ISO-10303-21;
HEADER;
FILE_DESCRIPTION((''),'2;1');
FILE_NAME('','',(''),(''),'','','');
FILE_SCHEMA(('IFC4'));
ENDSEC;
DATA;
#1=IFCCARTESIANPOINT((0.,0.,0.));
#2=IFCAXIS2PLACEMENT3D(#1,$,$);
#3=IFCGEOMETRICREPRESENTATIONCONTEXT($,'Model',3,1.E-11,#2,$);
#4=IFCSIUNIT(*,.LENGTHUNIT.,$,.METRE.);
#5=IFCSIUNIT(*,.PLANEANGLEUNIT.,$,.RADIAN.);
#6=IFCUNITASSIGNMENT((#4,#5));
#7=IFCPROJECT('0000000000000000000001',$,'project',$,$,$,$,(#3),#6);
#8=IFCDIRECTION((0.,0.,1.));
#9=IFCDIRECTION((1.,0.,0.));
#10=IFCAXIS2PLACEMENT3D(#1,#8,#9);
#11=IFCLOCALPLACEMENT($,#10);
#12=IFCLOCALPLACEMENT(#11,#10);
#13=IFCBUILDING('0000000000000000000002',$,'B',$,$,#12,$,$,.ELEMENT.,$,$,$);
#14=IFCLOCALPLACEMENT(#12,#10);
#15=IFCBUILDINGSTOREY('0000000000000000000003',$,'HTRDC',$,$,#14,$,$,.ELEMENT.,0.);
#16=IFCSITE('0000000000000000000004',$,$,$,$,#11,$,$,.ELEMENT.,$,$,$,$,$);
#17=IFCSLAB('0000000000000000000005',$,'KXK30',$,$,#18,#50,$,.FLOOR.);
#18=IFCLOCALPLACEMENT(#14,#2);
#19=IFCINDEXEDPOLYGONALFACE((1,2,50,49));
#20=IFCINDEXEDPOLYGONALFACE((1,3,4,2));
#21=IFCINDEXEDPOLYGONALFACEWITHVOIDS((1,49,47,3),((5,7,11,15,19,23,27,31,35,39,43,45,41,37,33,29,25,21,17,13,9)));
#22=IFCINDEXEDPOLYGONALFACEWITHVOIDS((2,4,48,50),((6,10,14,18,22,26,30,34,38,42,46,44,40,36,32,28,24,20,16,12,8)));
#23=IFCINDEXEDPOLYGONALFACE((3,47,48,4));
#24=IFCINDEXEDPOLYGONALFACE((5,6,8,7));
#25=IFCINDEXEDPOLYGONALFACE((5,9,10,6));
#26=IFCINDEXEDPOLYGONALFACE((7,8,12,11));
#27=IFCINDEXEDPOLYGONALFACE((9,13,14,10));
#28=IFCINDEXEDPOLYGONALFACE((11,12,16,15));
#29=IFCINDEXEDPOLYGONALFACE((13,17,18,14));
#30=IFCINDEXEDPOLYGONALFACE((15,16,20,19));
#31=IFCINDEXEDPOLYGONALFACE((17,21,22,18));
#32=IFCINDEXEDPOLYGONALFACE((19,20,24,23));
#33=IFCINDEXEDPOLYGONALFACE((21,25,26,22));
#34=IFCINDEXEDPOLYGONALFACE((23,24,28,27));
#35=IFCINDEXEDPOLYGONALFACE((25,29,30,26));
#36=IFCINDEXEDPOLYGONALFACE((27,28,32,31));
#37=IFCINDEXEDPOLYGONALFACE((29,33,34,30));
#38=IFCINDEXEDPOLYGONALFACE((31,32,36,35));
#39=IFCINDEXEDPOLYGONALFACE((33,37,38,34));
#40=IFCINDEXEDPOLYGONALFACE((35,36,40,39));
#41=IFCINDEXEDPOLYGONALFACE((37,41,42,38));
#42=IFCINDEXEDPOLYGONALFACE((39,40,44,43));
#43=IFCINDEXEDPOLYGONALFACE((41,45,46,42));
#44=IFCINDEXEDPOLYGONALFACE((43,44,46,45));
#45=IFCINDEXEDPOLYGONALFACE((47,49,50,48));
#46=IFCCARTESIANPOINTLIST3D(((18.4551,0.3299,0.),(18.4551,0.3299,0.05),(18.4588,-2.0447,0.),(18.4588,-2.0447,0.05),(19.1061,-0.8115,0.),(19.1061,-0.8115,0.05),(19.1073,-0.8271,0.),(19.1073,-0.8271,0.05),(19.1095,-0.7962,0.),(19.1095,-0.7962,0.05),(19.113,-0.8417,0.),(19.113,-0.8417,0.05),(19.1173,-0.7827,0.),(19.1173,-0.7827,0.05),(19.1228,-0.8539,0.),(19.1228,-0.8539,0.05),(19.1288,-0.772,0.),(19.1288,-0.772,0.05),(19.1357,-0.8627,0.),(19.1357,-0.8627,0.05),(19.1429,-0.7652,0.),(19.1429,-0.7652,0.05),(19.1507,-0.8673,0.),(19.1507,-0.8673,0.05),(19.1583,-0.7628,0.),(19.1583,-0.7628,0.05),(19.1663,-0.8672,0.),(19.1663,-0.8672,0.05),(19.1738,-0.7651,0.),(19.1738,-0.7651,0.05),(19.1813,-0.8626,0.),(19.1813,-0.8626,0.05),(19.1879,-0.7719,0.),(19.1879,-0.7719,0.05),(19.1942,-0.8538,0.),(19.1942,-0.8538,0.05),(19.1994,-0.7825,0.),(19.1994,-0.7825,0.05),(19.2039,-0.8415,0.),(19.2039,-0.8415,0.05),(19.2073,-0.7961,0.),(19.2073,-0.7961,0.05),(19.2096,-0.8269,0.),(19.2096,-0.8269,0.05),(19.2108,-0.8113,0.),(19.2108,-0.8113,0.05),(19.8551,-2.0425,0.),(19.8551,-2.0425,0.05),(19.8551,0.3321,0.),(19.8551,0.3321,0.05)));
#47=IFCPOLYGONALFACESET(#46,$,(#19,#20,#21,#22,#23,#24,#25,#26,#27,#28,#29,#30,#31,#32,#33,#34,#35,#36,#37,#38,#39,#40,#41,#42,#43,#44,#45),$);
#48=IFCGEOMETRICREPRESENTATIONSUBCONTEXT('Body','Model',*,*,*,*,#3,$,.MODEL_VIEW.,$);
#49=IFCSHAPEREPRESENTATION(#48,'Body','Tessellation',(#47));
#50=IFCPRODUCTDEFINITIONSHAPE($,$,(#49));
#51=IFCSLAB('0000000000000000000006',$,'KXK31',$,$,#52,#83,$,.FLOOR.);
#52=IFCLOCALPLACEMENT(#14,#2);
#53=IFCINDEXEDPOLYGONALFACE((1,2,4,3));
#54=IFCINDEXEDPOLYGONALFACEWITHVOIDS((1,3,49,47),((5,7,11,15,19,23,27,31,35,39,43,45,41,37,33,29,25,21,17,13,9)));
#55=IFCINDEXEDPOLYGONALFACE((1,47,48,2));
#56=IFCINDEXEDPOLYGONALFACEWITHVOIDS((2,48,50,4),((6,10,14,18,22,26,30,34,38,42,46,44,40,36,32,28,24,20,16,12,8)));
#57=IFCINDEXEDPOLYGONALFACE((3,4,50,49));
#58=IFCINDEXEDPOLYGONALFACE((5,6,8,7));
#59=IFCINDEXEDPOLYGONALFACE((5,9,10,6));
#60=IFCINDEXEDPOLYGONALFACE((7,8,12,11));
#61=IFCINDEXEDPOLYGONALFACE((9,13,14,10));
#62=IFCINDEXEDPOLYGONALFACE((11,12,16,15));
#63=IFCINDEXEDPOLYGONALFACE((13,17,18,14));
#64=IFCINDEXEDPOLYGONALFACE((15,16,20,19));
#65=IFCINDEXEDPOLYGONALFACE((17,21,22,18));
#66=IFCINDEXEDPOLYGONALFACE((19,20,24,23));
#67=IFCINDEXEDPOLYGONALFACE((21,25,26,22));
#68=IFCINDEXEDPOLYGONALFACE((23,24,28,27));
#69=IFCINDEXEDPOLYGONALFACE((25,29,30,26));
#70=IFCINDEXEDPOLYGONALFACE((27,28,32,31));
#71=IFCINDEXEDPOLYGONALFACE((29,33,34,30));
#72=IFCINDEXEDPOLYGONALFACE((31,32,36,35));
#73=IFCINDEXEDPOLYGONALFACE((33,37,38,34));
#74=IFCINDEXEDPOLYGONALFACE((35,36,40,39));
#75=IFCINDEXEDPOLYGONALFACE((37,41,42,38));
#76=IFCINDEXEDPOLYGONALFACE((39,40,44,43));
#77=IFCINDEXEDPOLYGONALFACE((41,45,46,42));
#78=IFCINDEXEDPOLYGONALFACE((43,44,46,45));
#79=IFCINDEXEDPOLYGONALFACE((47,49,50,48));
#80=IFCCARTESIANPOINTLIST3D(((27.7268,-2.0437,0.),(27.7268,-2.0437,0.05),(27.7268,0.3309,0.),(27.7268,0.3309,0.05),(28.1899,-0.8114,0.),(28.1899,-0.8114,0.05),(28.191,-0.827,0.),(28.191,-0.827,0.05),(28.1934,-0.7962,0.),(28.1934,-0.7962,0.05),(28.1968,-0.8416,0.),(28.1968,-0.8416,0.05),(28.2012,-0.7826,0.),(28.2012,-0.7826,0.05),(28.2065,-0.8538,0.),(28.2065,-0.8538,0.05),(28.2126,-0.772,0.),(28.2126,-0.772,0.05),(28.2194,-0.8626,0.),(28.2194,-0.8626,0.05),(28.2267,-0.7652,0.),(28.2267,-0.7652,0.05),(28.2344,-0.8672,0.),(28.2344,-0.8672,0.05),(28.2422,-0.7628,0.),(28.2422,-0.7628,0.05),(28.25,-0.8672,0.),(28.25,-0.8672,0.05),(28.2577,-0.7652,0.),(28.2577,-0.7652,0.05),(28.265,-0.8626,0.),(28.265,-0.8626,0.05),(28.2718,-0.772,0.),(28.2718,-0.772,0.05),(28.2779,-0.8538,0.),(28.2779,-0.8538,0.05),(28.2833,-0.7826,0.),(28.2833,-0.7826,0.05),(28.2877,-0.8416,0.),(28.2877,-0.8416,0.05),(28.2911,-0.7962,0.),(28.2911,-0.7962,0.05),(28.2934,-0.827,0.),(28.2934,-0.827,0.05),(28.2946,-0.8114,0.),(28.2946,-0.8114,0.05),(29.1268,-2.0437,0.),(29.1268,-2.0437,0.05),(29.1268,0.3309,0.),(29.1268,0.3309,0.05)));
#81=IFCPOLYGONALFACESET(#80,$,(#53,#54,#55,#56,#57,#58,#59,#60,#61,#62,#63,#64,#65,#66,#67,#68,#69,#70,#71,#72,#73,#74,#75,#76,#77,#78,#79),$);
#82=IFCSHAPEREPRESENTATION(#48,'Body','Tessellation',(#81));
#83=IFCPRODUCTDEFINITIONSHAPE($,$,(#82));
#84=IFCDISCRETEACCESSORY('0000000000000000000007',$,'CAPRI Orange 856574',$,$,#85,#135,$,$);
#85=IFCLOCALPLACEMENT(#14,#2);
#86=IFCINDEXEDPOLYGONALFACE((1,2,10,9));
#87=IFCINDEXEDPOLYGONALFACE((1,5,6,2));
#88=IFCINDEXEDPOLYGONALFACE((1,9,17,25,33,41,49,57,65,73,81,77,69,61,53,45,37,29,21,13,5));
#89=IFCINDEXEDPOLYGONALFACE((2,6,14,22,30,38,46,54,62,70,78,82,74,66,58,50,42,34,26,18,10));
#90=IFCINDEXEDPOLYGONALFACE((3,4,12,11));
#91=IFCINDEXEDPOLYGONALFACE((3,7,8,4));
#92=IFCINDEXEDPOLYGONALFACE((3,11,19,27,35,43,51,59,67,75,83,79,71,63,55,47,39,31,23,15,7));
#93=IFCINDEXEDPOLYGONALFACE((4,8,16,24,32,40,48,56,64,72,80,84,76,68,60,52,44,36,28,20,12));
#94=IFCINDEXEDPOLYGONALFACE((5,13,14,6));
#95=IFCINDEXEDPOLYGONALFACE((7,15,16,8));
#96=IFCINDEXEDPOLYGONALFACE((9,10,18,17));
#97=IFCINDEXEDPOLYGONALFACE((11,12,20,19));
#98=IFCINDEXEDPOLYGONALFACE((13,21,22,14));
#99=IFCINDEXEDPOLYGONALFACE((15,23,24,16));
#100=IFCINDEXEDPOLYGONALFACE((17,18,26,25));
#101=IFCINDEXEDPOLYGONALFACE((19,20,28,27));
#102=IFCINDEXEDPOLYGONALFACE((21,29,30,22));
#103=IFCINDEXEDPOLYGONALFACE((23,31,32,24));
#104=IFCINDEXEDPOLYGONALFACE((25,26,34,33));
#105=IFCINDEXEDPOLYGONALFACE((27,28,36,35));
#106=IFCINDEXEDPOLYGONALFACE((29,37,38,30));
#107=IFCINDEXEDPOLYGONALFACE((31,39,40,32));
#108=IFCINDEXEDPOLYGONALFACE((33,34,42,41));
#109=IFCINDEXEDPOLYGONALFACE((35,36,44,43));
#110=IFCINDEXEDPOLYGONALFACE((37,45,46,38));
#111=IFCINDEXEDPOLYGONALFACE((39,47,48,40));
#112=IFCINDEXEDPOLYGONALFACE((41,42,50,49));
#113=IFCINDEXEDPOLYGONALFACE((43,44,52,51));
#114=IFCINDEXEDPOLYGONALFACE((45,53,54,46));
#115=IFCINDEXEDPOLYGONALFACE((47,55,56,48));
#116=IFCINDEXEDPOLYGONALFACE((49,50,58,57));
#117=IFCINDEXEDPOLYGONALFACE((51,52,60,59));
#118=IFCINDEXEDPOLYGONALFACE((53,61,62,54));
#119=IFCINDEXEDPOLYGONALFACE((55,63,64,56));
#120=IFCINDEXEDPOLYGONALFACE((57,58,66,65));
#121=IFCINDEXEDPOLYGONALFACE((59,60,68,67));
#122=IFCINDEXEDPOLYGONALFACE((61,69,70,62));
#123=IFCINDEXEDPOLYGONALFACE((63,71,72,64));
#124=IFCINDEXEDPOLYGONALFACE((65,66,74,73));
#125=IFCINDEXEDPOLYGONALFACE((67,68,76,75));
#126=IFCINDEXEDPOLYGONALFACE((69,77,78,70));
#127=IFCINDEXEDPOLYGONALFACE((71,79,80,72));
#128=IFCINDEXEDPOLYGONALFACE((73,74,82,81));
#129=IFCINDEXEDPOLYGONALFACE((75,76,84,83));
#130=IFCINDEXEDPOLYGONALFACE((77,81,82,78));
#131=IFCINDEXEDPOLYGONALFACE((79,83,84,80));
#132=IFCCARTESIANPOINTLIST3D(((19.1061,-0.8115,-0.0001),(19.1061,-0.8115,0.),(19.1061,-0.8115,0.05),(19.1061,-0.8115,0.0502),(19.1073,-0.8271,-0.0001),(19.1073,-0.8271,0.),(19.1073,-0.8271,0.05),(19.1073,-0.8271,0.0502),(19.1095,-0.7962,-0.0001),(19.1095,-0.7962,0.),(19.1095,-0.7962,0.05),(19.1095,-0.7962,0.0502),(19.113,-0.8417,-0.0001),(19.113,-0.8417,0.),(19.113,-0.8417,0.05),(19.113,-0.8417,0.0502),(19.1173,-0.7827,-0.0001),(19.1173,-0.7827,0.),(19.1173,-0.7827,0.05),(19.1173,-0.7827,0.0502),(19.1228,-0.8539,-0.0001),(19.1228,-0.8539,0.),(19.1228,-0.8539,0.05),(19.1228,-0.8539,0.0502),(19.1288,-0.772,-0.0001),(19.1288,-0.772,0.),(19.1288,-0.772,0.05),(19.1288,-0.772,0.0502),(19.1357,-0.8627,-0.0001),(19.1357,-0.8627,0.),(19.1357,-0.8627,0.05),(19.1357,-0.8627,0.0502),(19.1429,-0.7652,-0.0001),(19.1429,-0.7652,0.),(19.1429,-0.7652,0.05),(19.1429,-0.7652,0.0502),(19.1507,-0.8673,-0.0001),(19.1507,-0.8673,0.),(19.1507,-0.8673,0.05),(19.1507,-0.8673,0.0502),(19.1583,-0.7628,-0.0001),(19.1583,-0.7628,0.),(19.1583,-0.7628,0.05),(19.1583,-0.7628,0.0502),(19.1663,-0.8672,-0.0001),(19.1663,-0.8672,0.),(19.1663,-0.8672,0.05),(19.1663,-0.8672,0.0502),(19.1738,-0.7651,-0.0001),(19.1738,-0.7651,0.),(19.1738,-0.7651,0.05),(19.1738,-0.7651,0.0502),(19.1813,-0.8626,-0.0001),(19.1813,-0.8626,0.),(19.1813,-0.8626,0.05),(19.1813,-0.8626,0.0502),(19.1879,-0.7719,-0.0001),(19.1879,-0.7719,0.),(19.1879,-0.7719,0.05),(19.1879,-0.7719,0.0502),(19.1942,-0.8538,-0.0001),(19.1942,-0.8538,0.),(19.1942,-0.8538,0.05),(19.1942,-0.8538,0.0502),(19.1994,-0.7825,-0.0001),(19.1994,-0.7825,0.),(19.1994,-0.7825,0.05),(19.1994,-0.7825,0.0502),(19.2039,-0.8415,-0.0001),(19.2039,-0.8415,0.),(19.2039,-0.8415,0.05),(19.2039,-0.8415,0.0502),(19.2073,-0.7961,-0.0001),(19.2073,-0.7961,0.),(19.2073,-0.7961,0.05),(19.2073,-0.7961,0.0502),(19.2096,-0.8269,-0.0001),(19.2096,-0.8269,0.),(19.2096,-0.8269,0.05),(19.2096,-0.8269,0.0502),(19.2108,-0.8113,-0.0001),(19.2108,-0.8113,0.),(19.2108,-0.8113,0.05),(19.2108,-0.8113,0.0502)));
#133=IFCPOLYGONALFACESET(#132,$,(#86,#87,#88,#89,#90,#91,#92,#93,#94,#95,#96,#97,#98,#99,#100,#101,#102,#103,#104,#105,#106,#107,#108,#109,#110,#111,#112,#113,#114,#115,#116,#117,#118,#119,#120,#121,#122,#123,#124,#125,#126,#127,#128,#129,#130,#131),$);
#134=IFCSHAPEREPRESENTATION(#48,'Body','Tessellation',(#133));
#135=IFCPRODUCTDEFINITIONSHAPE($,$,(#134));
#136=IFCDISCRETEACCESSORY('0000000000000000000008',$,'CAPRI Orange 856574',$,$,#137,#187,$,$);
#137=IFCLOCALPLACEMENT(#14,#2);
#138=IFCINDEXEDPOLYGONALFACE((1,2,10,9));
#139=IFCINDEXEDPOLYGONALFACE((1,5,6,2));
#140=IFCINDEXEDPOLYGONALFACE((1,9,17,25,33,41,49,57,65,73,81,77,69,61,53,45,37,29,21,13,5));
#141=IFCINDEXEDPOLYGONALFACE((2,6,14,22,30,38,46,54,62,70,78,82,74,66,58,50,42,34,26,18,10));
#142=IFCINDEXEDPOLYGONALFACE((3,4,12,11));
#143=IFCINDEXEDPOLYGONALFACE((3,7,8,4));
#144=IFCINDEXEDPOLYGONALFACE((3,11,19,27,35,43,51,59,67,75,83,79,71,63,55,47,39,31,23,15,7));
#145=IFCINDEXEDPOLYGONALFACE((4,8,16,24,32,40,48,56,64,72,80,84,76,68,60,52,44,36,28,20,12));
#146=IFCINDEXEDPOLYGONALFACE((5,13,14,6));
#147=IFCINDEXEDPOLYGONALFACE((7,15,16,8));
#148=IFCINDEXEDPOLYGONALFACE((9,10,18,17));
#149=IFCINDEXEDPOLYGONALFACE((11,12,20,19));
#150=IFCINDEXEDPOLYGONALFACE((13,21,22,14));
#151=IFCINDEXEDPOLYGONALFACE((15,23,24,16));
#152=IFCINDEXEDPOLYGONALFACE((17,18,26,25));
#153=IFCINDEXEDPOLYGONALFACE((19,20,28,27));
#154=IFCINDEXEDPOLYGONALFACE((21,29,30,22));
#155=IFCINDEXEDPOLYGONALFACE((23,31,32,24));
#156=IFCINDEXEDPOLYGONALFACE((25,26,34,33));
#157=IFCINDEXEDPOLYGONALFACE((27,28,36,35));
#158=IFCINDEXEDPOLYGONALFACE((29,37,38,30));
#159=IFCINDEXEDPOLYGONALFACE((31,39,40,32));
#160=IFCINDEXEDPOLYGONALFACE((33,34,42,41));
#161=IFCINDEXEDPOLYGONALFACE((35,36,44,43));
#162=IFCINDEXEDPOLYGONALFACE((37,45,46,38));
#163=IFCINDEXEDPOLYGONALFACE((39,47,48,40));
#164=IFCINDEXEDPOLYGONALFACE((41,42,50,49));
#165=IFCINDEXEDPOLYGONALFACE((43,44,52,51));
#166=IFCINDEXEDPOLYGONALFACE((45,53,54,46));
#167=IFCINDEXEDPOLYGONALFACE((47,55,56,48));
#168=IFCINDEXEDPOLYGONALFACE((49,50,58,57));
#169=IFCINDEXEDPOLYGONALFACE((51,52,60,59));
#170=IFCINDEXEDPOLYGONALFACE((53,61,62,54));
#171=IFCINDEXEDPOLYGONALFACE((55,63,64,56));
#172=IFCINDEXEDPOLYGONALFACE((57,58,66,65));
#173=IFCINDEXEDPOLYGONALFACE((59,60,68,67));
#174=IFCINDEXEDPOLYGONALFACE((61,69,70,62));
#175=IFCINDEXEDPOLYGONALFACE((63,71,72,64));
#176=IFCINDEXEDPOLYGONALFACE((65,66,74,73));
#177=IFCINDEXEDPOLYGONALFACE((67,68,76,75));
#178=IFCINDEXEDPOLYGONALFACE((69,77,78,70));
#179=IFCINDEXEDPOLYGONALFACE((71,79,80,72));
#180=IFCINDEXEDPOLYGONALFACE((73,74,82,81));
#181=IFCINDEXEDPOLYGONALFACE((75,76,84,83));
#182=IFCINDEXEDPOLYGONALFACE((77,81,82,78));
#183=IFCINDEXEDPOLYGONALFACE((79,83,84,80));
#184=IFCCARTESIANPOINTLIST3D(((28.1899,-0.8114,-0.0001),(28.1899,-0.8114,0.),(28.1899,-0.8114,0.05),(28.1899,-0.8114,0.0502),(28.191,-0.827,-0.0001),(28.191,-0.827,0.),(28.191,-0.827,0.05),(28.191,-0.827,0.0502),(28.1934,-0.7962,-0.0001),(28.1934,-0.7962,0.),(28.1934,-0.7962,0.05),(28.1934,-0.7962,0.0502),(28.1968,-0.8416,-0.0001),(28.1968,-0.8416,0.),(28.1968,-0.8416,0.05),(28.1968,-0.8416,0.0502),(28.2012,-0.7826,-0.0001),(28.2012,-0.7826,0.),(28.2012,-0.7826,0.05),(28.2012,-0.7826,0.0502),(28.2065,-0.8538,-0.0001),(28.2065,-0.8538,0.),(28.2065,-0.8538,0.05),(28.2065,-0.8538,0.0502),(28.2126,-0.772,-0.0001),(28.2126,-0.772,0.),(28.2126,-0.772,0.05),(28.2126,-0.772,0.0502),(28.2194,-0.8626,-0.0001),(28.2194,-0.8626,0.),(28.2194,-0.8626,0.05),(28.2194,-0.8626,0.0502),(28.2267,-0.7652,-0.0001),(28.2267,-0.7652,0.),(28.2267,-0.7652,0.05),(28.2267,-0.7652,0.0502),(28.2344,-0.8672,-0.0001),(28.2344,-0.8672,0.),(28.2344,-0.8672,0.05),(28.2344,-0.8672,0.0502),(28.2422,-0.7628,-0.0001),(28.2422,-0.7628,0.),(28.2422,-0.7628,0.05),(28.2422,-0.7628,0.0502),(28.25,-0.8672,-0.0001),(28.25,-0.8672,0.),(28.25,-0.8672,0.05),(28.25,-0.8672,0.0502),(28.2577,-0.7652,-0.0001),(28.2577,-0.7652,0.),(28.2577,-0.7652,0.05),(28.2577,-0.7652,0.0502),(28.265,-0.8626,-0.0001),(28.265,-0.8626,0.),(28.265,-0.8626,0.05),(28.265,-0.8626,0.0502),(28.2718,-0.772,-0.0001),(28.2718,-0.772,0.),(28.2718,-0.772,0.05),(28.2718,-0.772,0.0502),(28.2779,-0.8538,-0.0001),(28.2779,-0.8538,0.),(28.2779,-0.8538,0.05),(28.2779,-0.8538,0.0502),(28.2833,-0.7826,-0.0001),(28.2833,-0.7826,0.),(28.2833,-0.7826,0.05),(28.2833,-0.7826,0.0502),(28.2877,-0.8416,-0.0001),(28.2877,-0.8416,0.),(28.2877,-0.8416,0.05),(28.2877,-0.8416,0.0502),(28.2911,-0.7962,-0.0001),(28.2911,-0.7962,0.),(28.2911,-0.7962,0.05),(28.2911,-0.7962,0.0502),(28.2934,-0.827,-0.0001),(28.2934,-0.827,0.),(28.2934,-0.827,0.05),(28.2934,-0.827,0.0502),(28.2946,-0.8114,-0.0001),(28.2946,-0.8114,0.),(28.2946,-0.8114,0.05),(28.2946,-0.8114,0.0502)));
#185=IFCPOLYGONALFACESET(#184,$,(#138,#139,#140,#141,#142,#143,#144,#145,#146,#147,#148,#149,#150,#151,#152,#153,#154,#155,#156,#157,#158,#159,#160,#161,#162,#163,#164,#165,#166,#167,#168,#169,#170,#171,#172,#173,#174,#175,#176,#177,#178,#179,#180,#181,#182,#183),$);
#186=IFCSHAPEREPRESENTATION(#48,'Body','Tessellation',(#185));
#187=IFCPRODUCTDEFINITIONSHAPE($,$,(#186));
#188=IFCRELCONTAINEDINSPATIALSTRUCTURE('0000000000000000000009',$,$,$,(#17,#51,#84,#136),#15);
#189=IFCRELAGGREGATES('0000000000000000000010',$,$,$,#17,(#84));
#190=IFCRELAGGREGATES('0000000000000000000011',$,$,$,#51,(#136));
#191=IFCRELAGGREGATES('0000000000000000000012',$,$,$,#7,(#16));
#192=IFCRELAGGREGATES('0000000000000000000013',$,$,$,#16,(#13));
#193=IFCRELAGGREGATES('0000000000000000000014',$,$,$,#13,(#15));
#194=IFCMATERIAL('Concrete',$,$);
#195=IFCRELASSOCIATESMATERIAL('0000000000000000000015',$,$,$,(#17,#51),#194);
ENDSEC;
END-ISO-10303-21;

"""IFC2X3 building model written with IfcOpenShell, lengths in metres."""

from ifc_helpers import new_model, si_unit, frame, frame_2d, origin, origin_with_axes, origin_2d_with_axis, place, context, subcontext, project, spatial, polyline, circle, outline, extrude, material, element, aggregate, save


model = new_model("IFC2X3")

# Units and contexts
model_context = context("Model", 3, precision=1e-11, world=origin())
body_context = subcontext(model_context, "Body", "Model", "MODEL_VIEW")
ifc_project = project(units=[si_unit("LENGTHUNIT", "METRE"), si_unit("PLANEANGLEUNIT", "RADIAN")], contexts=[model_context])

# Site, building, storey
site_placement = place(None, origin_with_axes())
site = spatial("IfcSite", under=ifc_project, at=site_placement, CompositionType="ELEMENT")
building_placement = place(site_placement, origin_with_axes())
building = spatial("IfcBuilding", under=site, at=building_placement, Name="B", CompositionType="ELEMENT")
storey_placement = place(building_placement, origin_with_axes())
storey = spatial("IfcBuildingStorey", under=building, at=storey_placement, Name="HTRDC", CompositionType="ELEMENT", Elevation=0.0)

# Shared definitions
ifc_material = material(Name="Concrete")

# Slabs, openings
slab_1_placement = place(storey_placement, frame((18.4588, -2.0447, 0.0), z_axis=(0.0, 0.0, 1.0), x_axis=(0.999999, 0.001557, 0.0)))
slab_1 = element("IfcSlab", 1, at=slab_1_placement, inside=storey, material=ifc_material, Name="KXK30", PredefinedType="FLOOR", context=body_context, shape_type="SweptSolid", body=[
    extrude(outline(polyline([(0.0, 0.0), (0.0, -1.3963), (2.3746, -1.4), (2.3746, 0.0), (0.0, 0.0)])), frame((0.0, 0.0, 0.0), z_axis=(0.0, 0.0, 1.0), x_axis=(0.0, 1.0, 0.0)), (0.0, 0.0, 1.0), 0.05),
])
opening_1_placement = place(slab_1_placement, frame((0.7016, 1.2282, 0.0), z_axis=(0.0, 0.0, 1.0), x_axis=(1.0, 0.0, 0.0)))
element("IfcOpeningElement", 2, at=opening_1_placement, cuts=slab_1, ObjectType="Opening", context=body_context, shape_type="SweptSolid", body=[
    extrude(circle(Radius=0.0525, at=origin_2d_with_axis()), frame((0.0, 0.0, 0.0), z_axis=(0.0, 0.0, 1.0), x_axis=(0.0, 1.0, 0.0)), (0.0, 0.0, 1.0), 0.05),
])
slab_2_placement = place(storey_placement, frame((27.7268, -2.0437, 0.0), z_axis=(0.0, 0.0, 1.0), x_axis=(1.0, 0.0, 0.0)))
slab_2 = element("IfcSlab", 3, at=slab_2_placement, inside=storey, material=ifc_material, Name="KXK31", PredefinedType="FLOOR", context=body_context, shape_type="SweptSolid", body=[
    extrude(outline(polyline([(0.0, 0.0), (0.0, -1.4), (2.3746, -1.4), (2.3746, 0.0), (0.0, 0.0)])), frame((0.0, 0.0, 0.0), z_axis=(0.0, 0.0, 1.0), x_axis=(0.0, 1.0, 0.0)), (0.0, 0.0, 1.0), 0.05),
])
opening_2_placement = place(slab_2_placement, frame((0.5154, 1.2283, 0.0), z_axis=(0.0, 0.0, 1.0), x_axis=(1.0, 0.0, 0.0)))
element("IfcOpeningElement", 4, at=opening_2_placement, cuts=slab_2, ObjectType="Opening", context=body_context, shape_type="SweptSolid", body=[
    extrude(circle(Radius=0.0525, at=origin_2d_with_axis()), frame((0.0, 0.0, 0.0), z_axis=(0.0, 0.0, 1.0), x_axis=(0.0, 1.0, 0.0)), (0.0, 0.0, 1.0), 0.05),
])

# Discrete accessories
discrete_accessory_1_placement = place(storey_placement, frame((18.4588, -2.0447, -0.0001), z_axis=(0.0, 0.0, 1.0), x_axis=(0.999999, 0.001557, 0.0)))
discrete_accessory_1 = element("IfcDiscreteAccessory", 5, at=discrete_accessory_1_placement, inside=storey, Name="CAPRI Orange 856574", context=body_context, shape_type="SweptSolid", body=[
    extrude(circle(Radius=0.0525, at=frame_2d((1.2282, -0.7016), x_axis=(1.0, 0.0))), frame((0.0, 0.0, 0.0), z_axis=(0.0, 0.0, 1.0), x_axis=(0.0, 1.0, 0.0)), (0.0, 0.0, 1.0), 0.0503),
])
aggregate(slab_1, [discrete_accessory_1])
discrete_accessory_2_placement = place(storey_placement, frame((27.7268, -2.0437, -0.0001), z_axis=(0.0, 0.0, 1.0), x_axis=(1.0, 0.0, 0.0)))
discrete_accessory_2 = element("IfcDiscreteAccessory", 6, at=discrete_accessory_2_placement, inside=storey, Name="CAPRI Orange 856574", context=body_context, shape_type="SweptSolid", body=[
    extrude(circle(Radius=0.0525, at=frame_2d((1.2283, -0.5154), x_axis=(1.0, 0.0))), frame((0.0, 0.0, 0.0), z_axis=(0.0, 0.0, 1.0), x_axis=(0.0, 1.0, 0.0)), (0.0, 0.0, 1.0), 0.0503),
])
aggregate(slab_2, [discrete_accessory_2])

save(model, "model.ifc")
